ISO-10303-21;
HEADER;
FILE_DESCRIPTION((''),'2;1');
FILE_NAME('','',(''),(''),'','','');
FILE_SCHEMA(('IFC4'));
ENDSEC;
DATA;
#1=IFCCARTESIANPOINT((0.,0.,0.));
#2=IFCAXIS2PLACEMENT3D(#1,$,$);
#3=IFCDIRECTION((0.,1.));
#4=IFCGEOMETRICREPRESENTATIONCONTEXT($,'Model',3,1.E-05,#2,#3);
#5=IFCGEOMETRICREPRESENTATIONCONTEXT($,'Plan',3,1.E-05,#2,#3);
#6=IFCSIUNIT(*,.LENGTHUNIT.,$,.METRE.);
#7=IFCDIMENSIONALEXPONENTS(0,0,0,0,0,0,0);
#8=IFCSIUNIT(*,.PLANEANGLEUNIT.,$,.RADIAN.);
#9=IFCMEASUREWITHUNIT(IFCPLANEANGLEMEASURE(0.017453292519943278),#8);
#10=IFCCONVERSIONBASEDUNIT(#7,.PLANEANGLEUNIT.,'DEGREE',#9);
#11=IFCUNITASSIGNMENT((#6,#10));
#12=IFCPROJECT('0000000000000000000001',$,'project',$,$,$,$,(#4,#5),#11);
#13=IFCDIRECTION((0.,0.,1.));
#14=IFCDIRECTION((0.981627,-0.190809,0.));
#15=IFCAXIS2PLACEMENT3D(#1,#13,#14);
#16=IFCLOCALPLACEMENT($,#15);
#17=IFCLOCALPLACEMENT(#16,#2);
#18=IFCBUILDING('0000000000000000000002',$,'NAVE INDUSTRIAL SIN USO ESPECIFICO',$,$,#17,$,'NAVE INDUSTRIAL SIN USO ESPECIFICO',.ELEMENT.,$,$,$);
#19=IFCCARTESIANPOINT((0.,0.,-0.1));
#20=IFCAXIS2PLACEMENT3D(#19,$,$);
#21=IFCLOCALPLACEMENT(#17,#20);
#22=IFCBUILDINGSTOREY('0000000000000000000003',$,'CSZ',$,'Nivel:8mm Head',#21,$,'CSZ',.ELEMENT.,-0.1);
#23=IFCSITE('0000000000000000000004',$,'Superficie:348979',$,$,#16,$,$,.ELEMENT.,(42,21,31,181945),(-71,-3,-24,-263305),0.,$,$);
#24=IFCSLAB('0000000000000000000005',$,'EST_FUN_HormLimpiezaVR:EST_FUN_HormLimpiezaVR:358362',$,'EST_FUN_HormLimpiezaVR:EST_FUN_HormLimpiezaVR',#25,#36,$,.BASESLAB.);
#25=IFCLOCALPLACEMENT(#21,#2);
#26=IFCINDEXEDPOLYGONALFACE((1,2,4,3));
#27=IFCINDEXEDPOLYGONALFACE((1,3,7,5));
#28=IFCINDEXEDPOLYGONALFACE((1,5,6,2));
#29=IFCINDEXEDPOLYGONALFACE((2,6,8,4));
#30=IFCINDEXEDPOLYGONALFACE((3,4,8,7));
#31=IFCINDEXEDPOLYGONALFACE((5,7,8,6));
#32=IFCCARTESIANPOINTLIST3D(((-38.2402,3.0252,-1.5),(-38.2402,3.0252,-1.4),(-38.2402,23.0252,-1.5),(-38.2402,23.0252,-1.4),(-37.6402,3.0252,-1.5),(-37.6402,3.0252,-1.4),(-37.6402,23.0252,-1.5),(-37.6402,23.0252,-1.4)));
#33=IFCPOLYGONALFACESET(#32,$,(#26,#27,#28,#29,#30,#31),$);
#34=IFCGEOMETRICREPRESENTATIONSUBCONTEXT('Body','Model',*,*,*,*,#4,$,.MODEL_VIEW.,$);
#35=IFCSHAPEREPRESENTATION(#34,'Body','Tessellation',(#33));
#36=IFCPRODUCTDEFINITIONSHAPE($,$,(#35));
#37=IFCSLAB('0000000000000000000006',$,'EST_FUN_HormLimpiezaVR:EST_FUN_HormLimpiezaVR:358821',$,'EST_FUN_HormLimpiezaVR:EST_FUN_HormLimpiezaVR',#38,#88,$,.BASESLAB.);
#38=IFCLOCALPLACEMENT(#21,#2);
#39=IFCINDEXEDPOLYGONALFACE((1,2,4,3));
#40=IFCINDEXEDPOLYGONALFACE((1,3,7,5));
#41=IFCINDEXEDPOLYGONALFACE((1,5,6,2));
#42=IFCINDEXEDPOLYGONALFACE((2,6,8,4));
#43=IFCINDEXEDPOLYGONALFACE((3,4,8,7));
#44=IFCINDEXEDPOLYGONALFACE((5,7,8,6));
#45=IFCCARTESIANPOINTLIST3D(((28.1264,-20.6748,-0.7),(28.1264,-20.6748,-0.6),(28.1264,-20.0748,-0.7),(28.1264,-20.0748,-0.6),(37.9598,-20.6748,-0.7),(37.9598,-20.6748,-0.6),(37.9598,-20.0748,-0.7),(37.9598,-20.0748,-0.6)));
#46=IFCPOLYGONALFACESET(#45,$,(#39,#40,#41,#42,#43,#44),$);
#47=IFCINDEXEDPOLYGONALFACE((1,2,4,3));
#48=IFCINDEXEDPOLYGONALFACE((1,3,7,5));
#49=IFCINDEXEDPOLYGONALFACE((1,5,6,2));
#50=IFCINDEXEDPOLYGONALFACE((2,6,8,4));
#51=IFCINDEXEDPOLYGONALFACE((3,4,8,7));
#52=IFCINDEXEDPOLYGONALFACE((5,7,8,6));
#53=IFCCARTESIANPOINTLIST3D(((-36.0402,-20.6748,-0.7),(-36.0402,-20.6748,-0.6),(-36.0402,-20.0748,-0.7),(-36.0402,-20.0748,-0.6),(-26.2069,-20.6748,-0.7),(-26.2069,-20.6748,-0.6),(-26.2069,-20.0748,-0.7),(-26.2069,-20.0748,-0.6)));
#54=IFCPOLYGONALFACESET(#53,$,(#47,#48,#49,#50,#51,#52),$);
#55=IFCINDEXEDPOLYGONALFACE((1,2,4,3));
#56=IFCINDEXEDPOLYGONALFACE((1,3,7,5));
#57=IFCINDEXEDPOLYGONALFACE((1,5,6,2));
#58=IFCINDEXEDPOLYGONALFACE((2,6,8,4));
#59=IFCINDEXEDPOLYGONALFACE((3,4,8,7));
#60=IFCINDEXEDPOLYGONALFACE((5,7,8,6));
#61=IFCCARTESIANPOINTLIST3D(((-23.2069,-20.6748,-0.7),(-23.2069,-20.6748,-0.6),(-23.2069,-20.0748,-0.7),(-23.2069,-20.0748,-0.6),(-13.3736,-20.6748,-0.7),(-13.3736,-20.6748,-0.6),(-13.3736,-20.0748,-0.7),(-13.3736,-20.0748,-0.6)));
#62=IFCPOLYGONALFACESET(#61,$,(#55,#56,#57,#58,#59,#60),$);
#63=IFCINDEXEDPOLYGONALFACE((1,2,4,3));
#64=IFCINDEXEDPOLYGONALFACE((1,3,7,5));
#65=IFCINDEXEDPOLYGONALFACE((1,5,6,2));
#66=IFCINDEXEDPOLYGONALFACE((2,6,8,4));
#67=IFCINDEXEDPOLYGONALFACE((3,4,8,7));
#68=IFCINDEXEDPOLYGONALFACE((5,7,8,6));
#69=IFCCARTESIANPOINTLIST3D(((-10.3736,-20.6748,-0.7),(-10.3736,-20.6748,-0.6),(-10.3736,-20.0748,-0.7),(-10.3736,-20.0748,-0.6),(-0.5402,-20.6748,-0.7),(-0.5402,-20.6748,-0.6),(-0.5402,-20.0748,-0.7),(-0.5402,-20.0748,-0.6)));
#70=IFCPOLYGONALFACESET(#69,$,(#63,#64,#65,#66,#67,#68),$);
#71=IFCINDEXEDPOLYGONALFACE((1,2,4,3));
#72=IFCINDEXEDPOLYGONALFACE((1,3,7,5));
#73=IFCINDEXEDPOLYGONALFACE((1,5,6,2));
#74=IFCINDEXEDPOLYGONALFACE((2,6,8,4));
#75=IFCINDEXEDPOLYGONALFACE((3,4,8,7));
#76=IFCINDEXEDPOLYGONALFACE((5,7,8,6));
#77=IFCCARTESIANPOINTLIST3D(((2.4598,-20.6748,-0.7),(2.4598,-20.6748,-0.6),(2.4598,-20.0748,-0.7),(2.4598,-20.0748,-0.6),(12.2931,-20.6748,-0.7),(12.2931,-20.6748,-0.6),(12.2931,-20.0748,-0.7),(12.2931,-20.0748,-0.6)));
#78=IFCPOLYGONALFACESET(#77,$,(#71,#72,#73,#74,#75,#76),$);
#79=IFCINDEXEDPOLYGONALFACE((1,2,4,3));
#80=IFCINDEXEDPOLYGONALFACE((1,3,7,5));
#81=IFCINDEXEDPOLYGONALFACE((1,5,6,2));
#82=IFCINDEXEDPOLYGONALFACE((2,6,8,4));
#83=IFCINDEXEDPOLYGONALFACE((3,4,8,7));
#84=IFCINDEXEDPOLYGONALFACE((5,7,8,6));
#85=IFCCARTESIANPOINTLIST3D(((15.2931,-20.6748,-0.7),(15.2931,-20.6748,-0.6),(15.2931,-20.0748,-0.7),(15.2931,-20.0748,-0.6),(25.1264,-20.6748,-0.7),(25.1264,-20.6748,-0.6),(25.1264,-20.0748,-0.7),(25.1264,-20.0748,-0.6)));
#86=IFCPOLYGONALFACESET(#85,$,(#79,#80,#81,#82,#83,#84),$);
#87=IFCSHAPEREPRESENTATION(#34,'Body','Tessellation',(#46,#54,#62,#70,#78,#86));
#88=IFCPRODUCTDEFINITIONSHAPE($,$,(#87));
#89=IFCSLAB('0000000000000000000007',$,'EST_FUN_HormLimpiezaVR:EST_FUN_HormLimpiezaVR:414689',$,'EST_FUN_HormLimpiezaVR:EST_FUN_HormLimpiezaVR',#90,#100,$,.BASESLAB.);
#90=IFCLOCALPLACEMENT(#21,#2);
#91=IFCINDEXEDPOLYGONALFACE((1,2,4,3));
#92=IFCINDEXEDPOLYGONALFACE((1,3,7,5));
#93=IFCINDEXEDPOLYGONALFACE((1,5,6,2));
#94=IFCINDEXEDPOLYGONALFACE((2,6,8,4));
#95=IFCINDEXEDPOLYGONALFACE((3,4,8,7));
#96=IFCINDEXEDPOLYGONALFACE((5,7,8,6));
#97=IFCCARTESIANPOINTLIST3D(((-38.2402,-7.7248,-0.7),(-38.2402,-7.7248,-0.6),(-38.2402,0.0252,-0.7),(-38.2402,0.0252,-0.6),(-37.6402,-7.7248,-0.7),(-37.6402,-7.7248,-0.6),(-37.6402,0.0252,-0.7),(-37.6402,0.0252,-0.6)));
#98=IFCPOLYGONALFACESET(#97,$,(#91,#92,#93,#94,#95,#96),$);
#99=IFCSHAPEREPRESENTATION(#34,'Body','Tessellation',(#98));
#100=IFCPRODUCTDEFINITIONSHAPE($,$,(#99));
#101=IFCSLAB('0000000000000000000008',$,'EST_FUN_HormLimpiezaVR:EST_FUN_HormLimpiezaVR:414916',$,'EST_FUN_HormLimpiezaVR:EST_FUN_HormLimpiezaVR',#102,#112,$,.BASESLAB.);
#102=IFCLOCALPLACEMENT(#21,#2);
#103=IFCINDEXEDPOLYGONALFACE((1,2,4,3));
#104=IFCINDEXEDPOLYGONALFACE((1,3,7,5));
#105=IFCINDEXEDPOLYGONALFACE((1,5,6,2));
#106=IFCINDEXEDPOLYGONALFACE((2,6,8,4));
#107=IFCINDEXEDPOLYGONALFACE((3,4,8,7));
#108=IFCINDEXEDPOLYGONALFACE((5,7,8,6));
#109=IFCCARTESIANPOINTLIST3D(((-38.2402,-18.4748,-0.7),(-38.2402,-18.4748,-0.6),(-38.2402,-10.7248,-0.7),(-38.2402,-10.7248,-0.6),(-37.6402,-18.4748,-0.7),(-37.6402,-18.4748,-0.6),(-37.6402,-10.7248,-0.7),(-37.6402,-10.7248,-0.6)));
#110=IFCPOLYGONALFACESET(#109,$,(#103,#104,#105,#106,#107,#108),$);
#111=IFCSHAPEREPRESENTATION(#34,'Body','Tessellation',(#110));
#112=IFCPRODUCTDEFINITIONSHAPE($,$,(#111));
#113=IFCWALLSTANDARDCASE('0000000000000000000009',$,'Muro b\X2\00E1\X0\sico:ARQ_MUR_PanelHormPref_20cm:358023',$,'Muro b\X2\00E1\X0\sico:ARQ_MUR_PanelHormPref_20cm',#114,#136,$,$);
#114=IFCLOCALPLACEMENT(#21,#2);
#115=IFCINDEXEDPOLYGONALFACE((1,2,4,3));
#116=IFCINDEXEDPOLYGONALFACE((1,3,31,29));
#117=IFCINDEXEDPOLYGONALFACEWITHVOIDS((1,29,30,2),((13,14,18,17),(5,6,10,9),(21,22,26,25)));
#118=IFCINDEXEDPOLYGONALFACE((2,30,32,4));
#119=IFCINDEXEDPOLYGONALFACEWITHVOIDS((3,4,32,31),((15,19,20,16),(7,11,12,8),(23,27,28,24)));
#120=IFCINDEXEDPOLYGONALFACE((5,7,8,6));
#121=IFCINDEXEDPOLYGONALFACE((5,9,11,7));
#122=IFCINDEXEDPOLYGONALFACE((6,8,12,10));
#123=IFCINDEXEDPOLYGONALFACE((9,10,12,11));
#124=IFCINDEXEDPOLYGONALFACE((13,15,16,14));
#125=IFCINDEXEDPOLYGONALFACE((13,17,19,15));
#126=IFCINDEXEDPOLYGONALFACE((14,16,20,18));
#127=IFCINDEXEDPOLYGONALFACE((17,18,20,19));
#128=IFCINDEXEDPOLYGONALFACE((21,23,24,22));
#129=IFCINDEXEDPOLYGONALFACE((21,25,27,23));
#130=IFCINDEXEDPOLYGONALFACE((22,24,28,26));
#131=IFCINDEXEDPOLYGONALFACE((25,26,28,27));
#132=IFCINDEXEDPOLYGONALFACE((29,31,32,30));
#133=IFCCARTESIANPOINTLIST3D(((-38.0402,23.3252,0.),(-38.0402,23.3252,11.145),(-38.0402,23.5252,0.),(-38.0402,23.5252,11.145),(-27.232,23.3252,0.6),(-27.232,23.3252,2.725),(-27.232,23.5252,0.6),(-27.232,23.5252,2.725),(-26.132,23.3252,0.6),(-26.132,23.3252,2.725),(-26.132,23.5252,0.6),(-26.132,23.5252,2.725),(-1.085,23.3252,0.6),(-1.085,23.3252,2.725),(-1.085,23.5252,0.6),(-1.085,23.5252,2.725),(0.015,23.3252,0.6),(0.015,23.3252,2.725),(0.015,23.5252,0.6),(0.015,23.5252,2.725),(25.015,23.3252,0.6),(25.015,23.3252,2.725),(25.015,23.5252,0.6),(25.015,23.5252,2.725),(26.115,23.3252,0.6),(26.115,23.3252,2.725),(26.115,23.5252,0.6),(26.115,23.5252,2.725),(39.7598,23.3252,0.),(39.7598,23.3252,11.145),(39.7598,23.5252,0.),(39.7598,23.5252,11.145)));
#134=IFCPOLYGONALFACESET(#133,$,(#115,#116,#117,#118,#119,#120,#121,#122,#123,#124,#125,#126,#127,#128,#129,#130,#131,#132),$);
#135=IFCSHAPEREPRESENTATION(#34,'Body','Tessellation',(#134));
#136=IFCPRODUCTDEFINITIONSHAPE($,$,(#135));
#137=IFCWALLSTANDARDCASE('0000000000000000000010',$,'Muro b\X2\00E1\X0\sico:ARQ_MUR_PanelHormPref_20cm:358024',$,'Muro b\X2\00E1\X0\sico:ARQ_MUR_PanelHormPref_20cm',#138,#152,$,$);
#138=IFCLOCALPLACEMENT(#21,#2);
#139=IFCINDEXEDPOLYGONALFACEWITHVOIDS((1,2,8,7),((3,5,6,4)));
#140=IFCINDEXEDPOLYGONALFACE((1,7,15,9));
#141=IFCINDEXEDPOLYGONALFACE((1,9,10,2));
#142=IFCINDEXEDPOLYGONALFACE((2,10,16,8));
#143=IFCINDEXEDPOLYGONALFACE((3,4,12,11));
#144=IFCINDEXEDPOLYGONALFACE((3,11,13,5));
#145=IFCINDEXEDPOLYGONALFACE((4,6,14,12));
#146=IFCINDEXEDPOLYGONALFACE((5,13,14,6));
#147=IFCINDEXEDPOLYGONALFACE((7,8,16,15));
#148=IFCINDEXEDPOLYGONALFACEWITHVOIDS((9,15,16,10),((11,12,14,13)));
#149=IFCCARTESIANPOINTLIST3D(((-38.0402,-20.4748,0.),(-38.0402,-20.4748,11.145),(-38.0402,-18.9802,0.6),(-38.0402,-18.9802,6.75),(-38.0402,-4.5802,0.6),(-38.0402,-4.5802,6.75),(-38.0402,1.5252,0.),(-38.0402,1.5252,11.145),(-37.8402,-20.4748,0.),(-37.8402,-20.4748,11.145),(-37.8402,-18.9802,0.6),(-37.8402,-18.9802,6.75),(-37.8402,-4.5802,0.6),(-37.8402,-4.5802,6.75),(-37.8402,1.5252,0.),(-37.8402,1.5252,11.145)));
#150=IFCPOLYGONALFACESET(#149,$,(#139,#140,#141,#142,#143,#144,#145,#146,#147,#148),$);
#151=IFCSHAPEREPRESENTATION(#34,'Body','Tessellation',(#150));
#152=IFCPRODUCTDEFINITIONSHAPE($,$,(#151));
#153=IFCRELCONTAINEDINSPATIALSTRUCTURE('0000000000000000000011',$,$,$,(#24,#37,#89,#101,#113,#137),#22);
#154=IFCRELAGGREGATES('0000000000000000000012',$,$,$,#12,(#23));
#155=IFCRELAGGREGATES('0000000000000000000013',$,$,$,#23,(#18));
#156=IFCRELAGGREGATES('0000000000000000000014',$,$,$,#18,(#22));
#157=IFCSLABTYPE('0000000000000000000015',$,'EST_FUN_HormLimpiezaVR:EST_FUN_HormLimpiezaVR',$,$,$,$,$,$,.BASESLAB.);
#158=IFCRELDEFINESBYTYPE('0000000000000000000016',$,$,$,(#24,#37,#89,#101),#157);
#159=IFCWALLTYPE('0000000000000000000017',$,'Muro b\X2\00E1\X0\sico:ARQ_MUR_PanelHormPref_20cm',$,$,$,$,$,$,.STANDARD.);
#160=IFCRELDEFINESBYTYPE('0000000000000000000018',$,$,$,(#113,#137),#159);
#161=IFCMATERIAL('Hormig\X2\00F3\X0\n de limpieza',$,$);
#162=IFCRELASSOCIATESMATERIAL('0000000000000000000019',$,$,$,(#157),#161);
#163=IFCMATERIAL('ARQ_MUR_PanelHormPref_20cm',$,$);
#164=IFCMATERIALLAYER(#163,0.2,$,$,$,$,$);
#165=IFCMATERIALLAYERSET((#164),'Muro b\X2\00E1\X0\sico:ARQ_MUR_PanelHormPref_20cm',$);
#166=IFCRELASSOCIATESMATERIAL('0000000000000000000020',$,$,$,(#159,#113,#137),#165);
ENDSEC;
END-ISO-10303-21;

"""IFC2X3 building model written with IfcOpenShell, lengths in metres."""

from ifc_helpers import new_model, entity, si_unit, converted_unit, direction, frame, frame_2d, origin, origin_2d_with_axis, place, context, subcontext, project, spatial, rectangle, extrude, material, layer, layer_set, layer_usage, type_object, element, save


model = new_model("IFC2X3")

# Units and contexts
model_context = context("Model", 3, precision=1e-05, world=origin(), true_north=direction((0.0, 1.0)))
plan_context = context("Plan", 3, precision=1e-05, world=origin(), true_north=direction((0.0, 1.0)))
body_context = subcontext(model_context, "Body", "Model", "MODEL_VIEW")
ifc_project = project(units=[si_unit("LENGTHUNIT", "METRE"), converted_unit("PLANEANGLEUNIT", "DEGREE", entity("IfcPlaneAngleMeasure", 0.017453292519943278), si_unit("PLANEANGLEUNIT", "RADIAN"), dimensions=[0, 0, 0, 0, 0, 0, 0])], contexts=[model_context, plan_context])

# Site, building, storey
site_placement = place(None, frame((0.0, 0.0, 0.0), z_axis=(0.0, 0.0, 1.0), x_axis=(0.981627, -0.190809, 0.0)))
site = spatial("IfcSite", under=ifc_project, at=site_placement, Name="Superficie:348979", CompositionType="ELEMENT", RefLatitude=(42, 21, 31, 181945), RefLongitude=(-71, -3, -24, -263305), RefElevation=0.0)
building_placement = place(site_placement, origin())
building = spatial("IfcBuilding", under=site, at=building_placement, Name="NAVE INDUSTRIAL SIN USO ESPECIFICO", LongName="NAVE INDUSTRIAL SIN USO ESPECIFICO", CompositionType="ELEMENT")
storey_placement = place(building_placement, frame((0.0, 0.0, -0.1)))
storey = spatial("IfcBuildingStorey", under=building, at=storey_placement, Name="CSZ", ObjectType="Nivel:8mm Head", LongName="CSZ", CompositionType="ELEMENT", Elevation=-0.1)

# Slabs
ifc_material_1 = material(Name="Hormigón de limpieza")
slab_type_1 = type_object("IfcSlabType", Name="EST_FUN_HormLimpiezaVR:EST_FUN_HormLimpiezaVR", PredefinedType="BASESLAB", material=ifc_material_1)
slab_1_placement = place(storey_placement, frame((-38.2402, 3.0252, -1.5)))
element("IfcSlab", 1, at=slab_1_placement, inside=storey, type_object=slab_type_1, Name="EST_FUN_HormLimpiezaVR:EST_FUN_HormLimpiezaVR:358362", ObjectType="EST_FUN_HormLimpiezaVR:EST_FUN_HormLimpiezaVR", PredefinedType="BASESLAB", context=body_context, shape_type="SweptSolid", body=[
    extrude(rectangle(XDim=20.0, YDim=0.6, at=frame_2d((0.0, 0.0), x_axis=(1.0, 0.0))), frame((0.3, 10.0, 0.0), z_axis=(0.0, 0.0, 1.0), x_axis=(0.0, 1.0, 0.0)), (0.0, 0.0, 1.0), 0.1),
])
slab_2_placement = place(storey_placement, frame((-36.0402, -20.6748, -0.7)))
element("IfcSlab", 2, at=slab_2_placement, inside=storey, type_object=slab_type_1, Name="EST_FUN_HormLimpiezaVR:EST_FUN_HormLimpiezaVR:358821", ObjectType="EST_FUN_HormLimpiezaVR:EST_FUN_HormLimpiezaVR", PredefinedType="BASESLAB", context=body_context, shape_type="SweptSolid", body=[
    extrude(rectangle(XDim=9.8333, YDim=0.6, at=origin_2d_with_axis()), frame((69.0833, 0.3, 0.0)), (0.0, 0.0, 1.0), 0.1),
    extrude(rectangle(XDim=9.8333, YDim=0.6, at=frame_2d((0.0, 0.0), x_axis=(1.0, 0.0))), frame((4.9167, 0.3, 0.0)), (0.0, 0.0, 1.0), 0.1),
    extrude(rectangle(XDim=9.8333, YDim=0.6, at=frame_2d((0.0, 0.0), x_axis=(1.0, 0.0))), frame((17.75, 0.3, 0.0)), (0.0, 0.0, 1.0), 0.1),
    extrude(rectangle(XDim=9.8333, YDim=0.6, at=frame_2d((0.0, 0.0), x_axis=(1.0, 0.0))), frame((30.5833, 0.3, 0.0)), (0.0, 0.0, 1.0), 0.1),
    extrude(rectangle(XDim=9.8333, YDim=0.6, at=frame_2d((0.0, 0.0), x_axis=(1.0, 0.0))), frame((43.4167, 0.3, 0.0)), (0.0, 0.0, 1.0), 0.1),
    extrude(rectangle(XDim=9.8333, YDim=0.6, at=origin_2d_with_axis()), frame((56.25, 0.3, 0.0)), (0.0, 0.0, 1.0), 0.1),
])
slab_3_placement = place(storey_placement, frame((-38.2402, -7.7248, -0.7)))
element("IfcSlab", 3, at=slab_3_placement, inside=storey, type_object=slab_type_1, Name="EST_FUN_HormLimpiezaVR:EST_FUN_HormLimpiezaVR:414689", ObjectType="EST_FUN_HormLimpiezaVR:EST_FUN_HormLimpiezaVR", PredefinedType="BASESLAB", context=body_context, shape_type="SweptSolid", body=[
    extrude(rectangle(XDim=7.75, YDim=0.6, at=frame_2d((0.0, 0.0), x_axis=(1.0, 0.0))), frame((0.3, 3.875, 0.0), z_axis=(0.0, 0.0, 1.0), x_axis=(0.0, 1.0, 0.0)), (0.0, 0.0, 1.0), 0.1),
])
slab_4_placement = place(storey_placement, frame((-38.2402, -18.4748, -0.7)))
element("IfcSlab", 4, at=slab_4_placement, inside=storey, type_object=slab_type_1, Name="EST_FUN_HormLimpiezaVR:EST_FUN_HormLimpiezaVR:414916", ObjectType="EST_FUN_HormLimpiezaVR:EST_FUN_HormLimpiezaVR", PredefinedType="BASESLAB", context=body_context, shape_type="SweptSolid", body=[
    extrude(rectangle(XDim=7.75, YDim=0.6, at=frame_2d((0.0, 0.0), x_axis=(1.0, 0.0))), frame((0.3, 3.875, 0.0), z_axis=(0.0, 0.0, 1.0), x_axis=(0.0, 1.0, 0.0)), (0.0, 0.0, 1.0), 0.1),
])

# Wall, openings
ifc_material_2 = material(Name="ARQ_MUR_PanelHormPref_20cm")
ifc_layer_1 = layer(ifc_material_2, 0.2)
ifc_layer_set_1 = layer_set([ifc_layer_1], Name="Muro básico:ARQ_MUR_PanelHormPref_20cm")
ifc_layer_usage_1 = layer_usage(ifc_layer_set_1, "AXIS2", "NEGATIVE", 0.1)
wall_type_1 = type_object("IfcWallType", Name="Muro básico:ARQ_MUR_PanelHormPref_20cm", PredefinedType="STANDARD", material=ifc_layer_set_1)
wall_1_placement = place(storey_placement, frame((-38.0402, 23.4252, 0.0)))
wall_1 = element("IfcWallStandardCase", 5, at=wall_1_placement, inside=storey, type_object=wall_type_1, material=ifc_layer_usage_1, Name="Muro básico:ARQ_MUR_PanelHormPref_20cm:358023", ObjectType="Muro básico:ARQ_MUR_PanelHormPref_20cm", context=body_context, shape_type="SweptSolid", body=[
    extrude(rectangle(XDim=77.8, YDim=0.2, at=frame_2d((38.9, 0.0), x_axis=(-1.0, 0.0))), origin(), (0.0, 0.0, 1.0), 11.145),
])
opening_1_placement = place(wall_1_placement, frame((36.9553, -0.1, 0.6)))
element("IfcOpeningElement", 6, at=opening_1_placement, cuts=wall_1, ObjectType="Opening", context=body_context, shape_type="SweptSolid", body=[
    extrude(rectangle(XDim=2.125, YDim=1.1, at=frame_2d((1.0625, 0.55), x_axis=(1.0, 0.0))), frame((0.0, 0.0, 0.0), z_axis=(0.0, 1.0, 0.0), x_axis=(0.0, 0.0, 1.0)), (0.0, 0.0, 1.0), 0.2),
])
opening_2_placement = place(wall_1_placement, frame((63.0553, -0.1, 0.6)))
element("IfcOpeningElement", 7, at=opening_2_placement, cuts=wall_1, ObjectType="Opening", context=body_context, shape_type="SweptSolid", body=[
    extrude(rectangle(XDim=2.125, YDim=1.1, at=frame_2d((1.0625, 0.55), x_axis=(1.0, 0.0))), frame((0.0, 0.0, 0.0), z_axis=(0.0, 1.0, 0.0), x_axis=(0.0, 0.0, 1.0)), (0.0, 0.0, 1.0), 0.2),
])
opening_3_placement = place(wall_1_placement, frame((10.8083, -0.1, 0.6)))
element("IfcOpeningElement", 8, at=opening_3_placement, cuts=wall_1, ObjectType="Opening", context=body_context, shape_type="SweptSolid", body=[
    extrude(rectangle(XDim=2.125, YDim=1.1, at=frame_2d((1.0625, 0.55), x_axis=(1.0, 0.0))), frame((0.0, 0.0, 0.0), z_axis=(0.0, 1.0, 0.0), x_axis=(0.0, 0.0, 1.0)), (0.0, 0.0, 1.0), 0.2),
])

# Wall, opening
ifc_layer_usage_2 = layer_usage(ifc_layer_set_1, "AXIS2", "NEGATIVE", 0.1)
wall_2_placement = place(storey_placement, frame((-37.9402, -20.4748, 0.0), z_axis=(0.0, 0.0, 1.0), x_axis=(0.0, 1.0, 0.0)))
wall_2 = element("IfcWallStandardCase", 9, at=wall_2_placement, inside=storey, type_object=wall_type_1, material=ifc_layer_usage_2, Name="Muro básico:ARQ_MUR_PanelHormPref_20cm:358024", ObjectType="Muro básico:ARQ_MUR_PanelHormPref_20cm", context=body_context, shape_type="SweptSolid", body=[
    extrude(rectangle(XDim=22.0, YDim=0.2, at=frame_2d((11.0, 0.0), x_axis=(-1.0, 0.0))), origin(), (0.0, 0.0, 1.0), 11.145),
])
opening_4_placement = place(wall_2_placement, frame((1.4946, 0.2524, 0.6)))
element("IfcOpeningElement", 10, at=opening_4_placement, cuts=wall_2, ObjectType="Opening", context=body_context, shape_type="SweptSolid", body=[
    extrude(rectangle(XDim=6.15, YDim=14.4, at=frame_2d((0.0, 0.0), x_axis=(0.0, 1.0))), frame((7.2, -0.5048, 3.075), z_axis=(0.0, 1.0, 0.0), x_axis=(-1.0, 0.0, 0.0)), (0.0, 0.0, 1.0), 0.5048),
])

save(model, "model.ifc")
